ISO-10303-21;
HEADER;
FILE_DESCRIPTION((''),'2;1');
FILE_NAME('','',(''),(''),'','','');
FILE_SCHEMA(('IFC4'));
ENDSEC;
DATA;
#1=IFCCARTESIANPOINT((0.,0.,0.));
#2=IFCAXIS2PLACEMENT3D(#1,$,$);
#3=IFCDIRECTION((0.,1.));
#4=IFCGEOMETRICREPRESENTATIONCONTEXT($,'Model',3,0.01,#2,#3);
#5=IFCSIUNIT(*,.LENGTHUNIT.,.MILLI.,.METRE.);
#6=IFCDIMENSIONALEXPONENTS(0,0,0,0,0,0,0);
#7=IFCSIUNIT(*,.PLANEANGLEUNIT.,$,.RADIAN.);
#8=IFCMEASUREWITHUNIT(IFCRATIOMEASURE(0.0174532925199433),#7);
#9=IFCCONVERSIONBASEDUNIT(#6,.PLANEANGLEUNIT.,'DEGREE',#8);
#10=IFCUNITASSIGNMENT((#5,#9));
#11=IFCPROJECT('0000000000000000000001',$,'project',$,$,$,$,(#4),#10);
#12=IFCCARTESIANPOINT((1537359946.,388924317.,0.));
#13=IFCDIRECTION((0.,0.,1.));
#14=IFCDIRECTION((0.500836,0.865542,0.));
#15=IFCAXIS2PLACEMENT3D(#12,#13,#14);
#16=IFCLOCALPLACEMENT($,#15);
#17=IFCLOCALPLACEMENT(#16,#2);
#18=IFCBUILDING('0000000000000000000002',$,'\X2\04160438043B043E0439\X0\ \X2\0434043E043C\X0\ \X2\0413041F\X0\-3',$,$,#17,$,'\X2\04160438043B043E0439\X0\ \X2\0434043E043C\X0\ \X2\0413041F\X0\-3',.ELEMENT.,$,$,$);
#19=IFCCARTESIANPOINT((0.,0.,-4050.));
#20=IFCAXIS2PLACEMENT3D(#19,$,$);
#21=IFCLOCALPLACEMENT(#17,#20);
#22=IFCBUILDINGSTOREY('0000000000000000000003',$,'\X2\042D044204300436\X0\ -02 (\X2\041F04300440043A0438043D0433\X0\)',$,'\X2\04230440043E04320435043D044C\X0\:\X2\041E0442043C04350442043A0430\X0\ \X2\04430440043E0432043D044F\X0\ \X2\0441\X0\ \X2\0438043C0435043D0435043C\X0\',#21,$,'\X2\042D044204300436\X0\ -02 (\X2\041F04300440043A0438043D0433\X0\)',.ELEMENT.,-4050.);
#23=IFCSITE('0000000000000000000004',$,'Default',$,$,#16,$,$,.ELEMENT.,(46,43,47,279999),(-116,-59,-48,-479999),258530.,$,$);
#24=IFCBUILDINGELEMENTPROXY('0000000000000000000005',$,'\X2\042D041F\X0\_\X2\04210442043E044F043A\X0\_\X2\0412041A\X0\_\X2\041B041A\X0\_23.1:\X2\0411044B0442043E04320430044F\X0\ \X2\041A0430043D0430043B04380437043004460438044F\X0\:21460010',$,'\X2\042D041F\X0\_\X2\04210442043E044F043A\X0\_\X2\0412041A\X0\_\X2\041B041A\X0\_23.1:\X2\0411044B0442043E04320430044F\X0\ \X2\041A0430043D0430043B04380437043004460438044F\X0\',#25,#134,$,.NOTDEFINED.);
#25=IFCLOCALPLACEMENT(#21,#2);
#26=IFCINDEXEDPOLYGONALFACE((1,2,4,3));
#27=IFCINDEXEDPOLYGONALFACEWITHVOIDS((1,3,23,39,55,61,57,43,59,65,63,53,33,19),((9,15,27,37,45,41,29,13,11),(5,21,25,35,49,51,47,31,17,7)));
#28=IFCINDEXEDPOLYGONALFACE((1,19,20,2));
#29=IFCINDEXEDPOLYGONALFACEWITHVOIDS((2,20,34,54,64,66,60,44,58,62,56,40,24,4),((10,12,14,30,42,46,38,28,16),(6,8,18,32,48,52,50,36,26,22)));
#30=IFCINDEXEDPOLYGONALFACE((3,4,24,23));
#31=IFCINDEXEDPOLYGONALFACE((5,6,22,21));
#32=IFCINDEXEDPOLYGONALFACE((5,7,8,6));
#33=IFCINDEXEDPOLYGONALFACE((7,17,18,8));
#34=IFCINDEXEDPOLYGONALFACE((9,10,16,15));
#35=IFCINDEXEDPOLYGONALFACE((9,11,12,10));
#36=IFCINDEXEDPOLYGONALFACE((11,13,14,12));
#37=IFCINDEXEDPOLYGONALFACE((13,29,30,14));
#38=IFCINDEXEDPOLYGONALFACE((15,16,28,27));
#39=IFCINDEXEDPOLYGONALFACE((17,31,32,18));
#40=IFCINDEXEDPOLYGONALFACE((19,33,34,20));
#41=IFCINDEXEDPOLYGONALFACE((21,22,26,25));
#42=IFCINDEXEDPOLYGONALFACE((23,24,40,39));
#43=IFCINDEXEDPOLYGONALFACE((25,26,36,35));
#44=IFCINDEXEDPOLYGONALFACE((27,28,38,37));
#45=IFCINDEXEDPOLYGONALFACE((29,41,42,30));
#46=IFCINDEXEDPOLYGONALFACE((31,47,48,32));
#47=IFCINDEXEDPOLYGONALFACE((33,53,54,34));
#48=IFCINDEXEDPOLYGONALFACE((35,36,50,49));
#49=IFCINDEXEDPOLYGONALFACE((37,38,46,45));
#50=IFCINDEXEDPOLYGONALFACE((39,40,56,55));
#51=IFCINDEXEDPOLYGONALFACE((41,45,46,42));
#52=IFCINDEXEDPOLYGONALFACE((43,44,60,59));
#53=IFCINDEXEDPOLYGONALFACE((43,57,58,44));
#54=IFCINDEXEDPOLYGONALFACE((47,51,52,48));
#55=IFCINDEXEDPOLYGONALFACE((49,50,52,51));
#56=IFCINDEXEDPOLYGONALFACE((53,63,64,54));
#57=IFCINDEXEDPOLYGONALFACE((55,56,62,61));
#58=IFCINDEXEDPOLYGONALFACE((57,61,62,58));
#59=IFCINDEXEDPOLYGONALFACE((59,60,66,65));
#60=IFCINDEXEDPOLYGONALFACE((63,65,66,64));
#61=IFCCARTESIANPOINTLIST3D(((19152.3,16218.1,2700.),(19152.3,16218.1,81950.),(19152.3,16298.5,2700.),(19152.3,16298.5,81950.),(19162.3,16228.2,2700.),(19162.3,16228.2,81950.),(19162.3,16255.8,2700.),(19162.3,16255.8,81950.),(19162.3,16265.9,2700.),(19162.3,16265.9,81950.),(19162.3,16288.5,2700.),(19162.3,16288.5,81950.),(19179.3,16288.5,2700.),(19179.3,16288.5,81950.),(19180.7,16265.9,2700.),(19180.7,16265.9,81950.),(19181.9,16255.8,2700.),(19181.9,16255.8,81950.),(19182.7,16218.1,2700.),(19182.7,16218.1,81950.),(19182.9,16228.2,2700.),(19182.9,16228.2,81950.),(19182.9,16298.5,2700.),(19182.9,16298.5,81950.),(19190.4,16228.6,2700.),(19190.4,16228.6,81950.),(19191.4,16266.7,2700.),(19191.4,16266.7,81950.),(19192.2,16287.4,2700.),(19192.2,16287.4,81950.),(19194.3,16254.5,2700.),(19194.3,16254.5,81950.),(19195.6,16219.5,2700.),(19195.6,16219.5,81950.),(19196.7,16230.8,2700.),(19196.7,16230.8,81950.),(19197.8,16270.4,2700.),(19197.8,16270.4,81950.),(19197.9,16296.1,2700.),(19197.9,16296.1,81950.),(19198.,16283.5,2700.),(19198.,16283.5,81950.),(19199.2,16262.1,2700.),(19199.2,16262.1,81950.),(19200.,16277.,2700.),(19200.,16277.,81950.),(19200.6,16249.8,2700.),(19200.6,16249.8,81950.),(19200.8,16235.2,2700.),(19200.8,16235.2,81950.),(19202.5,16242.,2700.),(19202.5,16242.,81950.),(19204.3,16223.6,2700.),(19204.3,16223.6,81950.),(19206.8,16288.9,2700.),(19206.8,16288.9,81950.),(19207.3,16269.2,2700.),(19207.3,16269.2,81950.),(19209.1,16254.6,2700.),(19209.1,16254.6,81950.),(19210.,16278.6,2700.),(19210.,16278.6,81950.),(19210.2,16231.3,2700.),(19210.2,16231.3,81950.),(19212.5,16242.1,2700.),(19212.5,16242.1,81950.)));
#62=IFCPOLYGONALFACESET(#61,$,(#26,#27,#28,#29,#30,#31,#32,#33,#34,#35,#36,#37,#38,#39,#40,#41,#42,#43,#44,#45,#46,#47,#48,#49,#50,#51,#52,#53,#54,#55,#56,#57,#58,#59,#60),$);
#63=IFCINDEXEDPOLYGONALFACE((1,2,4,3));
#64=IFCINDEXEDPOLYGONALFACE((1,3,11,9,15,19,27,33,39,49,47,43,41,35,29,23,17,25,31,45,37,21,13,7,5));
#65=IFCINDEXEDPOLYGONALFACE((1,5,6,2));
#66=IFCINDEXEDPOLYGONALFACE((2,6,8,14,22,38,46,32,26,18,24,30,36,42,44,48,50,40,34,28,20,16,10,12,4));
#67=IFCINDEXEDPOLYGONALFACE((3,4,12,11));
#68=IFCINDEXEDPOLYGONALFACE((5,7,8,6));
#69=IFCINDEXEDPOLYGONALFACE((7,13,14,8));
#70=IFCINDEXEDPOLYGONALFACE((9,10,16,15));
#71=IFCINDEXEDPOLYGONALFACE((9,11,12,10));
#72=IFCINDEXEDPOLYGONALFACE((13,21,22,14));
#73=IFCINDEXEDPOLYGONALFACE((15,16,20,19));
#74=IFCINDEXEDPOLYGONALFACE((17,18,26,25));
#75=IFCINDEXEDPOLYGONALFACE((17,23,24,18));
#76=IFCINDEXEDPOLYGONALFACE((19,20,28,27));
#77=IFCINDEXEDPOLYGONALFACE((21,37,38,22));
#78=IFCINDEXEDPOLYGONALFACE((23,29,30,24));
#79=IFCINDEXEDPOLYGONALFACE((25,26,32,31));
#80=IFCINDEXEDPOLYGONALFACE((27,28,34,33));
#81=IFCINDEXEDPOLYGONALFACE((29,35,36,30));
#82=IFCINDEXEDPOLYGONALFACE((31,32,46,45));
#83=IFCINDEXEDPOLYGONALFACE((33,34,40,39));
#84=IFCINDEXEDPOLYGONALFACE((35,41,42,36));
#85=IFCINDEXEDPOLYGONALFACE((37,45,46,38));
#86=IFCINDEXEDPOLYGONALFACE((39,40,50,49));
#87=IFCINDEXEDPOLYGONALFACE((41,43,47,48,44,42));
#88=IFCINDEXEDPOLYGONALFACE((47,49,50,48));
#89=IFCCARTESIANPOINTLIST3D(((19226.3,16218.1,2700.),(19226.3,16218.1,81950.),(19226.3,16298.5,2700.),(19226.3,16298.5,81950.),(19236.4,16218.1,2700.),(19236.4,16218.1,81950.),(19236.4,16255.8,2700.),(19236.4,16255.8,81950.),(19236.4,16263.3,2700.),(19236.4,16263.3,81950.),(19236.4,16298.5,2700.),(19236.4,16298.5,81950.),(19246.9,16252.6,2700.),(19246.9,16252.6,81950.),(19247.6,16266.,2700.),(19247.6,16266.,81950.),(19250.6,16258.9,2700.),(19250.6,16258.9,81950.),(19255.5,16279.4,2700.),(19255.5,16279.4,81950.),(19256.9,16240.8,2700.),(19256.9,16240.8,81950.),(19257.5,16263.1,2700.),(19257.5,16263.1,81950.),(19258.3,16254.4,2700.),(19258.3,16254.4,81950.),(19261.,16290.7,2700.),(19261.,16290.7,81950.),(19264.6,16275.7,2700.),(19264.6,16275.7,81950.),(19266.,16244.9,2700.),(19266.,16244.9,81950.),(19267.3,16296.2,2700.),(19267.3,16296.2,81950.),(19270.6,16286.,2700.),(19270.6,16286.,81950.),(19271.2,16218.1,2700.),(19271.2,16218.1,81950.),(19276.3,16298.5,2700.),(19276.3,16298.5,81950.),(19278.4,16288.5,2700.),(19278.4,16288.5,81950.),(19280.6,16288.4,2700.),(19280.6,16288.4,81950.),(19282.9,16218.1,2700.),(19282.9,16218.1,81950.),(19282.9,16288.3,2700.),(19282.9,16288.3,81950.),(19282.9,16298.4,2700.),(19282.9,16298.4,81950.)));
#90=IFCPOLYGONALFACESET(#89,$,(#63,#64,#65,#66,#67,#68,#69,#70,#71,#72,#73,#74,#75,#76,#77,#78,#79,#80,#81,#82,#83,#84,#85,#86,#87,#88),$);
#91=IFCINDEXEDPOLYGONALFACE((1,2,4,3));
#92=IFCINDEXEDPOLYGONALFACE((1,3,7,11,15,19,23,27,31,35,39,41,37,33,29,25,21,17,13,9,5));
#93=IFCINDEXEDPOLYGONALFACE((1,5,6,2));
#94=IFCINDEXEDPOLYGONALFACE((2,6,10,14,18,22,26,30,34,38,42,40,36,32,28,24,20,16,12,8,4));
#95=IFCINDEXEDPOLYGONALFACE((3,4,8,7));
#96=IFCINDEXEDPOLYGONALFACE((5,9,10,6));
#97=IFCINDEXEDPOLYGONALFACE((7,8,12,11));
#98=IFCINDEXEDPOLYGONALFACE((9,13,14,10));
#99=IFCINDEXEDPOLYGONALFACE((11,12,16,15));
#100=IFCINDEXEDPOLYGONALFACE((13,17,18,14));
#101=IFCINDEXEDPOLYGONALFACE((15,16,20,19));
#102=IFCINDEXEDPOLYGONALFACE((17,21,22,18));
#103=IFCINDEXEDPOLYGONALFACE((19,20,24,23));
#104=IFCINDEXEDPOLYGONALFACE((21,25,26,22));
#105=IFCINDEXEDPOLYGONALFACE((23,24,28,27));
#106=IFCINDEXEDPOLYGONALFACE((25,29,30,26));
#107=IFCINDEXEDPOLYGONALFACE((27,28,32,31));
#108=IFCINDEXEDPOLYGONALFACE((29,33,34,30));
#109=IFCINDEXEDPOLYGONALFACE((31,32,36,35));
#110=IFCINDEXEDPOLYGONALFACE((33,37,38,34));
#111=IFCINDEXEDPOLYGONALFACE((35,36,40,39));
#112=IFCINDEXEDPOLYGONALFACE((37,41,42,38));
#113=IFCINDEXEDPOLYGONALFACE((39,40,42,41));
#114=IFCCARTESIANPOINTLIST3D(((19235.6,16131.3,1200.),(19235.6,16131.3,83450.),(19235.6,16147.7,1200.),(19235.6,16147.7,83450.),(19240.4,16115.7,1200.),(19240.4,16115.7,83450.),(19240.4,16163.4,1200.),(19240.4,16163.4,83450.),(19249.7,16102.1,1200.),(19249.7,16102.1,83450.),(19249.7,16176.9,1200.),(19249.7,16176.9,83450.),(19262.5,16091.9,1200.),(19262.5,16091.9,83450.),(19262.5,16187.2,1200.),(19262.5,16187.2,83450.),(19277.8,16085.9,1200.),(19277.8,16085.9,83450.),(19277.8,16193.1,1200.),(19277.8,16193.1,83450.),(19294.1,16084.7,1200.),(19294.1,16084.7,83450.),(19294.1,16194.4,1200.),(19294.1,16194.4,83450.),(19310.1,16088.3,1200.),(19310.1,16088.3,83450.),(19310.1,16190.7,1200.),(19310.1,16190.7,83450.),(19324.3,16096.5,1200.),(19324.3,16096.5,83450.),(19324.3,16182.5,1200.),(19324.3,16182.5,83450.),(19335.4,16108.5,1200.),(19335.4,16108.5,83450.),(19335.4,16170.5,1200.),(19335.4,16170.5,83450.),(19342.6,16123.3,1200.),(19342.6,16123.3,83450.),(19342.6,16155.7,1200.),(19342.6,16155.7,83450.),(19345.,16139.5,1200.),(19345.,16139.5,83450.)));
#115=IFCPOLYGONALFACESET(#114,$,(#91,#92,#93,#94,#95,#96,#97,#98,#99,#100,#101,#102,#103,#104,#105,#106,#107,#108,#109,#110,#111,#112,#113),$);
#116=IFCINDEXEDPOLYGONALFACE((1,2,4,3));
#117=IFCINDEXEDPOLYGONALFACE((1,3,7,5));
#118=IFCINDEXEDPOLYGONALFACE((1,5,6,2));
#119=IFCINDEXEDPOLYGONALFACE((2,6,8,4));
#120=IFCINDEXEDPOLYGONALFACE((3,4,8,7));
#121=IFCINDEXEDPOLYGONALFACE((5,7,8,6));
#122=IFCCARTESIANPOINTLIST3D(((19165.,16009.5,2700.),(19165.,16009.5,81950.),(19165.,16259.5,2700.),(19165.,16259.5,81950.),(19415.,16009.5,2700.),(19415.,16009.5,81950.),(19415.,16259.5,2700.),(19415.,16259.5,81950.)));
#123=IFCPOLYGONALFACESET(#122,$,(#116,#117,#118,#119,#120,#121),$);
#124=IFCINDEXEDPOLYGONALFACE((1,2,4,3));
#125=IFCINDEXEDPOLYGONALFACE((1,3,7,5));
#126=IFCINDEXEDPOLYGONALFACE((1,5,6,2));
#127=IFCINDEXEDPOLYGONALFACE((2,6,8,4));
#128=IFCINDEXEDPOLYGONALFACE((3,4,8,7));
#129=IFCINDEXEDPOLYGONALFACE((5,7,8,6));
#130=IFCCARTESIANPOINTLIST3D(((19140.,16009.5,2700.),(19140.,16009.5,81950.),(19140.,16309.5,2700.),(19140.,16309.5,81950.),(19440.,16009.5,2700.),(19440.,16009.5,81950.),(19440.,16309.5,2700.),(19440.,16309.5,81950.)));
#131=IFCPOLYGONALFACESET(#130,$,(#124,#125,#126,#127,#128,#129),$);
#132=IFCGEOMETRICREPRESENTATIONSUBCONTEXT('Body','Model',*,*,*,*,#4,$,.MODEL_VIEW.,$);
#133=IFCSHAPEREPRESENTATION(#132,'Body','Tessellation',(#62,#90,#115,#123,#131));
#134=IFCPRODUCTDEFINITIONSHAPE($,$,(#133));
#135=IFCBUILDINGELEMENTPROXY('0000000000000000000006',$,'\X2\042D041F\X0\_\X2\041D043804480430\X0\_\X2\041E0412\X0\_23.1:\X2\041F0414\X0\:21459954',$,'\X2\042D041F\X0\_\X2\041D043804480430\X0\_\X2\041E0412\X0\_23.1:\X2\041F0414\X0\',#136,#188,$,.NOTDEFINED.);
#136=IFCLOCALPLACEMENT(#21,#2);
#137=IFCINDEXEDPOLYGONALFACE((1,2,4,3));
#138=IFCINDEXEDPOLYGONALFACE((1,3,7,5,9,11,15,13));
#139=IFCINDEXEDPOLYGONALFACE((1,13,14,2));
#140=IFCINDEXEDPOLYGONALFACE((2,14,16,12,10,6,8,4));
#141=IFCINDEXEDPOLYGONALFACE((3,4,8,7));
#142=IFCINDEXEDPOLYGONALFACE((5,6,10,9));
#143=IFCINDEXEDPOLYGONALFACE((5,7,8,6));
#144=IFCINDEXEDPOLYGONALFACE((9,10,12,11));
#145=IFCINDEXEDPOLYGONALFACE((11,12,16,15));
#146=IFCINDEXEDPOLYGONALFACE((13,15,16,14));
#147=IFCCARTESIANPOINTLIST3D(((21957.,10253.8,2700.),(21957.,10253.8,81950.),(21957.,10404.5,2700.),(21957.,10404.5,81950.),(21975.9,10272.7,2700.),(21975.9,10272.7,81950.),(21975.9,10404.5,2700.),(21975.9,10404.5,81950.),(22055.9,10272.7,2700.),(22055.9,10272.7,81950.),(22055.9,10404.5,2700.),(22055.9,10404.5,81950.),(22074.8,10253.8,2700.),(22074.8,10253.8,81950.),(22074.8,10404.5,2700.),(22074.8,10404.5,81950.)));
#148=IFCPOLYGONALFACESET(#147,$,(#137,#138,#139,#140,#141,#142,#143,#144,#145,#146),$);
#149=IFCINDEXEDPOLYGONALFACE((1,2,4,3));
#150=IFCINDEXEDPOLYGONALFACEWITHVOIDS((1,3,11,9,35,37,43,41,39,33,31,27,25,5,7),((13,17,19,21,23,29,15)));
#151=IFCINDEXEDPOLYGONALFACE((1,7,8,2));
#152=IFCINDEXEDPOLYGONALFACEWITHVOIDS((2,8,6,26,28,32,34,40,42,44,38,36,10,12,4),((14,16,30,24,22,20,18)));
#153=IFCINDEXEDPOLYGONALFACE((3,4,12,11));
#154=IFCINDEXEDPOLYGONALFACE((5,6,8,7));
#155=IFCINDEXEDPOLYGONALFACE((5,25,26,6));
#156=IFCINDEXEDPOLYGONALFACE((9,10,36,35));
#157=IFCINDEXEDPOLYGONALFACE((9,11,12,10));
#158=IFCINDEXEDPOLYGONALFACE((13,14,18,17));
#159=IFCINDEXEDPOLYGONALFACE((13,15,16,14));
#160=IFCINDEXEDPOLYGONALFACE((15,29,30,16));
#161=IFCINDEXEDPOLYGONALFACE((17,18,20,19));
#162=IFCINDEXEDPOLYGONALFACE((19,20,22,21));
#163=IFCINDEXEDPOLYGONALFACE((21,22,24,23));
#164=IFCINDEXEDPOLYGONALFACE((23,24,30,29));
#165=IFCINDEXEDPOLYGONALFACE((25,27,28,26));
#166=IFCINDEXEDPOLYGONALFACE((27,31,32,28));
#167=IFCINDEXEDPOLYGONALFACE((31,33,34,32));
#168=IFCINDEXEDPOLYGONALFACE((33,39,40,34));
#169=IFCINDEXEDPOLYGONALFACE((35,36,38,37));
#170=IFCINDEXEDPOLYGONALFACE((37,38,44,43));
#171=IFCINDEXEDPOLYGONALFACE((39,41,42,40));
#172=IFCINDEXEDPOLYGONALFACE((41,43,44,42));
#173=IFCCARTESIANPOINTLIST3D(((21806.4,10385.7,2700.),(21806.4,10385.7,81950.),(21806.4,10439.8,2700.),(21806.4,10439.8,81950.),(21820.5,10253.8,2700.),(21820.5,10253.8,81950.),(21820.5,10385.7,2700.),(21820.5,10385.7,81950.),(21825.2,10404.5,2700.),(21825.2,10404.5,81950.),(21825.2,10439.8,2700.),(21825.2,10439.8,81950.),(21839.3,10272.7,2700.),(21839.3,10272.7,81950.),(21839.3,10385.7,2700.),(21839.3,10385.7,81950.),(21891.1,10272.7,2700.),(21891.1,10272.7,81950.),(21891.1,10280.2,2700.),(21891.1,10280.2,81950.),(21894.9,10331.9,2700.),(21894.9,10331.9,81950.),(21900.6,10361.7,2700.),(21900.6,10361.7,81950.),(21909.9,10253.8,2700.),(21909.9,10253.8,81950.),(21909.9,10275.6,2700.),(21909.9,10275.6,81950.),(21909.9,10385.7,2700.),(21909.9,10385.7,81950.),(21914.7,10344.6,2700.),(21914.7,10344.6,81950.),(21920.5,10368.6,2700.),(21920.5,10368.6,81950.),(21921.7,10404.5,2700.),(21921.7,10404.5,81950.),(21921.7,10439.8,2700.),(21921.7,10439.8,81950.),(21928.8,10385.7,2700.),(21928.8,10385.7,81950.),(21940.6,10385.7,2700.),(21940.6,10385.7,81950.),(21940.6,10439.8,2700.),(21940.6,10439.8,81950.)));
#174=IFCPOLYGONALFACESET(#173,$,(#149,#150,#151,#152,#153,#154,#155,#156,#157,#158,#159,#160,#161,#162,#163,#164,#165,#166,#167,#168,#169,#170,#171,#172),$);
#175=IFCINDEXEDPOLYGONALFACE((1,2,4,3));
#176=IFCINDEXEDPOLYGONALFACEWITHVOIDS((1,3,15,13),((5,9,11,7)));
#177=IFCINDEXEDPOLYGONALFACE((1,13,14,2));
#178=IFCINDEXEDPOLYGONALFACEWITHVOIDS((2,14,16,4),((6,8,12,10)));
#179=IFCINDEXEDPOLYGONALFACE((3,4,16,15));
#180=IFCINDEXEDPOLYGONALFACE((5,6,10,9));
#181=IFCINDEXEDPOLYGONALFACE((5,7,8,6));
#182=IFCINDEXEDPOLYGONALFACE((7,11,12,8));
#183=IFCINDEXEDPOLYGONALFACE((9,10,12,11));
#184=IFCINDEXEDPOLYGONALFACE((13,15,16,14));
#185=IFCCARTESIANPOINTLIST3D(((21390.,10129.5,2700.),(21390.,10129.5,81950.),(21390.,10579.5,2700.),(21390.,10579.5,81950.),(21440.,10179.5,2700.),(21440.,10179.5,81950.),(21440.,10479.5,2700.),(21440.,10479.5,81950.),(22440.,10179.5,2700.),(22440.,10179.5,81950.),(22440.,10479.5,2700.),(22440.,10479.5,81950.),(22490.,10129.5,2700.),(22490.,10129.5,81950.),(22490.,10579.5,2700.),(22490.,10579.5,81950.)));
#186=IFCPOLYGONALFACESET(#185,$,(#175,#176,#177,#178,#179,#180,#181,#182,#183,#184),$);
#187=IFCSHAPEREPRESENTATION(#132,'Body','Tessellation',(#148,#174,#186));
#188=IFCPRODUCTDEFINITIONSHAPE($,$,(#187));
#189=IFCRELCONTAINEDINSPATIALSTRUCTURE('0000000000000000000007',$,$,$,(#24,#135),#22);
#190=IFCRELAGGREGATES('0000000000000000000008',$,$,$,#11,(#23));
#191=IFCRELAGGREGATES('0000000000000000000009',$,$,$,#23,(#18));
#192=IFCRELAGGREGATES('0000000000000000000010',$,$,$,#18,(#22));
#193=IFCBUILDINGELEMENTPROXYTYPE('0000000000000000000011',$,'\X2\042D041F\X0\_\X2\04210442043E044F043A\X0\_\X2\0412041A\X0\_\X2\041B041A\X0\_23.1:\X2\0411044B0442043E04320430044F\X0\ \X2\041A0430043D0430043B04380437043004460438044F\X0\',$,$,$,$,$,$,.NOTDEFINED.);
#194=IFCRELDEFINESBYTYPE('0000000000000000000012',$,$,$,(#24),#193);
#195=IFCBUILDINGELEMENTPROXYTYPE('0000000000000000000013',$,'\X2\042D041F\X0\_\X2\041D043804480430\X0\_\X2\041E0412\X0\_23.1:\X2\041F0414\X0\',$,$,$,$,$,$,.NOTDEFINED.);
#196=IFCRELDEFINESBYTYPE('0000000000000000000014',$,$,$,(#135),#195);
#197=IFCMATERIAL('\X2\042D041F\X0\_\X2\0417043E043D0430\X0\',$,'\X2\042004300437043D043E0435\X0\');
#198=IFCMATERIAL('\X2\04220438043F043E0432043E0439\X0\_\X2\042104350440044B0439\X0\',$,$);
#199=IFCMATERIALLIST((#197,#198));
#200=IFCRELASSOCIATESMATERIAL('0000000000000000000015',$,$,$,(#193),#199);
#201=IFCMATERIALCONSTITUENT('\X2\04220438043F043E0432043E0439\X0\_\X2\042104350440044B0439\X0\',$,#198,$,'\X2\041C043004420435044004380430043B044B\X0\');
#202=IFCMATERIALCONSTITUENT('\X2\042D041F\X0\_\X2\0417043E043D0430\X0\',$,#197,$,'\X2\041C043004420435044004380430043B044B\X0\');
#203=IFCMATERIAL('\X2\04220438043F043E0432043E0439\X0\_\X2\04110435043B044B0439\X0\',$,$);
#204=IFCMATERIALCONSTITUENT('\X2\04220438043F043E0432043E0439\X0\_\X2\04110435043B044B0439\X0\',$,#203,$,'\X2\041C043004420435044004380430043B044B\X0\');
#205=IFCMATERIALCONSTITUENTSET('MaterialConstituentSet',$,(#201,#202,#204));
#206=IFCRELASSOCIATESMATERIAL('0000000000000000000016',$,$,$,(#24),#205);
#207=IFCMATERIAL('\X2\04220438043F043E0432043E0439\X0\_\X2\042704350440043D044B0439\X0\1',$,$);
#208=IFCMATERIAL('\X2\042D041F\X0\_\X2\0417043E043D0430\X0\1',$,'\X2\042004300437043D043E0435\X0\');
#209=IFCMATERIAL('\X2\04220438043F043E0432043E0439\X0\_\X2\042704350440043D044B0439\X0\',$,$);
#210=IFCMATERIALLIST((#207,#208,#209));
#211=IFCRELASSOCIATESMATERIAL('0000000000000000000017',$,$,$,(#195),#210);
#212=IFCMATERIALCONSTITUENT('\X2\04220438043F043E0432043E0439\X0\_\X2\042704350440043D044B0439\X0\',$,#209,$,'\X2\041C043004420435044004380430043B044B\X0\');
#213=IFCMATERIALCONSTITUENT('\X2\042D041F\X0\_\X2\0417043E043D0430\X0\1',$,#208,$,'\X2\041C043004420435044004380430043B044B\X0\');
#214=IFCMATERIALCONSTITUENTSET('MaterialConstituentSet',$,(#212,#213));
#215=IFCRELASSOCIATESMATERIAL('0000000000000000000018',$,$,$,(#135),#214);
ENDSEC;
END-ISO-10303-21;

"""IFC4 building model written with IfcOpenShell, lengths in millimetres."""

from ifc_helpers import new_model, entity, si_unit, converted_unit, direction, frame, frame_2d, origin, place, context, subcontext, project, spatial, polyline, rectangle, circle, outline, extrude, source, transform, mapped, material, material_list, constituent, constituent_set, type_object, type_shapes, element, save


model = new_model("IFC4")

# Units and contexts
model_context = context("Model", 3, precision=0.01, world=origin(), true_north=direction((0.0, 1.0)))
body_context = subcontext(model_context, "Body", "Model", "MODEL_VIEW")
ifc_project = project(units=[si_unit("LENGTHUNIT", "METRE", prefix="MILLI"), converted_unit("PLANEANGLEUNIT", "DEGREE", entity("IfcRatioMeasure", 0.0174532925199433), si_unit("PLANEANGLEUNIT", "RADIAN"), dimensions=[0, 0, 0, 0, 0, 0, 0])], contexts=[model_context])

# Site, building, storey
site_placement = place(None, frame((1537359946.0, 388924317.0, 0.0), z_axis=(0.0, 0.0, 1.0), x_axis=(0.500836, 0.865542, 0.0)))
site = spatial("IfcSite", under=ifc_project, at=site_placement, Name="Default", CompositionType="ELEMENT", RefLatitude=(46, 43, 47, 279999), RefLongitude=(-116, -59, -48, -479999), RefElevation=258530.0)
building_placement = place(site_placement, origin())
building = spatial("IfcBuilding", under=site, at=building_placement, Name="Жилой дом ГП-3", LongName="Жилой дом ГП-3", CompositionType="ELEMENT")
storey_placement = place(building_placement, frame((0.0, 0.0, -4050.0)))
storey = spatial("IfcBuildingStorey", under=building, at=storey_placement, Name="Этаж -02 (Паркинг)", ObjectType="Уровень:Отметка уровня с именем", LongName="Этаж -02 (Паркинг)", CompositionType="ELEMENT", Elevation=-4050.0)

# Building element proxies
ifc_material_1 = material(Name="Типовой_Черный")
ifc_material_2 = material(Name="ЭП_Зона", Category="Разное")
ifc_material_3 = material(Name="Типовой_Белый")
ifc_material_4 = material(Name="ЭП_Зона1", Category="Разное")
ifc_material_5 = material(Name="Типовой_Черный1")
ifc_material_6 = material(Name="Типовой_Серый")
ifc_material_list_1 = material_list([ifc_material_2, ifc_material_6])
building_element_proxy_type_1 = type_object("IfcBuildingElementProxyType", Name="ЭП_Стояк_ВК_ЛК_23.1:Бытовая Канализация", PredefinedType="NOTDEFINED", material=ifc_material_list_1)
shared_shape_1 = source(origin(), body_context, "Body", "SweptSolid", [
    extrude(outline(polyline([(-42.2, -39.0), (-11.8, -39.0), (1.1, -37.6), (9.8, -33.5), (15.7, -25.8), (18.0, -15.0), (14.6, -2.5), (4.7, 5.0), (12.8, 12.1), (15.5, 21.5), (12.3, 31.8), (3.4, 39.0), (-11.6, 41.4), (-42.2, 41.4), (-42.2, -39.0)]), holes=[polyline([(-32.2, 8.8), (-32.2, 31.4), (-15.2, 31.4), (-2.3, 30.3), (3.5, 26.4), (5.5, 19.9), (3.3, 13.3), (-3.1, 9.6), (-13.9, 8.8), (-32.2, 8.8)]), polyline([(-32.2, -28.9), (-32.2, -1.3), (-12.6, -1.3), (-0.2, -2.6), (6.1, -7.3), (8.0, -15.1), (6.3, -21.9), (2.2, -26.3), (-4.1, -28.5), (-11.6, -28.9), (-32.2, -28.9)])]), frame((54.5, -52.4, -1350.0)), (0.0, 0.0, 1.0), 79250.0),
    extrude(outline(polyline([(-32.1, -31.9), (48.3, -31.9), (48.3, -21.8), (10.6, -21.8), (13.8, -11.4), (25.6, -1.3), (48.3, 13.0), (48.3, 24.6), (21.4, 7.7), (12.0, 0.1), (7.4, -7.7), (3.3, -0.7), (-9.3, 6.4), (-19.7, 12.3), (-22.1, 20.2), (-22.0, 22.4), (-22.0, 24.6), (-32.0, 24.6), (-32.1, 18.0), (-29.9, 9.0), (-24.3, 2.8), (-13.1, -2.8), (0.4, -10.6), (3.0, -21.8), (-32.1, -21.8), (-32.1, -31.9)])), frame((118.2, -43.1, -1350.0), z_axis=(0.0, 0.0, 1.0), x_axis=(0.0, -1.0, 0.0)), (0.0, 0.0, 1.0), 79250.0),
    extrude(circle(Radius=55.0, at=frame_2d((0.0, 0.0), x_axis=(1.0, 0.0))), frame((150.0, -170.0, -2850.0)), (0.0, 0.0, 1.0), 82250.0),
    extrude(rectangle(XDim=250.0, YDim=250.0, at=frame_2d((0.0, 0.0), x_axis=(1.0, 0.0))), frame((150.0, -175.0, -1350.0)), (0.0, 0.0, 1.0), 79250.0),
    extrude(rectangle(XDim=300.0, YDim=300.0, at=frame_2d((0.0, 0.0), x_axis=(1.0, 0.0))), frame((150.0, -150.0, -1350.0)), (0.0, 0.0, 1.0), 79250.0),
])
type_shapes(building_element_proxy_type_1, [shared_shape_1])
ifc_constituent_1 = constituent(ifc_material_6, Name="Типовой_Серый", Category="Материалы")
ifc_constituent_2 = constituent(ifc_material_2, Name="ЭП_Зона", Category="Материалы")
ifc_constituent_3 = constituent(ifc_material_3, Name="Типовой_Белый", Category="Материалы")
ifc_constituent_set_1 = constituent_set(constituents=[ifc_constituent_1, ifc_constituent_2, ifc_constituent_3], Name="MaterialConstituentSet")
proxy_1_placement = place(storey_placement, frame((19140.0, 16309.5, 4050.0)))
element("IfcBuildingElementProxy", 1, at=proxy_1_placement, inside=storey, type_object=building_element_proxy_type_1, material=ifc_constituent_set_1, Name="ЭП_Стояк_ВК_ЛК_23.1:Бытовая Канализация:21460010", ObjectType="ЭП_Стояк_ВК_ЛК_23.1:Бытовая Канализация", PredefinedType="NOTDEFINED", context=body_context, shape_type="MappedRepresentation", body=[
    mapped(shared_shape_1, transform((0.0, 0.0, 0.0), scale=1.0)),
])
ifc_constituent_4 = constituent(ifc_material_1, Name="Типовой_Черный", Category="Материалы")
ifc_constituent_5 = constituent(ifc_material_4, Name="ЭП_Зона1", Category="Материалы")
ifc_constituent_set_2 = constituent_set(constituents=[ifc_constituent_4, ifc_constituent_5], Name="MaterialConstituentSet")
ifc_material_list_2 = material_list([ifc_material_5, ifc_material_4, ifc_material_1])
building_element_proxy_type_2 = type_object("IfcBuildingElementProxyType", Name="ЭП_Ниша_ОВ_23.1:ПД", PredefinedType="NOTDEFINED", material=ifc_material_list_2)
shared_shape_2 = source(origin(), body_context, "Body", "SweptSolid", [
    extrude(outline(polyline([(-80.1, -58.9), (70.6, -58.9), (70.6, -40.0), (-61.2, -40.0), (-61.2, 40.0), (70.6, 40.0), (70.6, 58.9), (-80.1, 58.9), (-80.1, -58.9)])), frame((474.1, 245.6, 0.0), z_axis=(0.0, 0.0, 1.0), x_axis=(0.0, -1.0, 0.0)), (0.0, 0.0, 1.0), 79250.0),
    extrude(outline(polyline([(-120.0, 29.1), (-120.0, -60.4), (11.8, -60.4), (11.8, -74.5), (66.0, -74.5), (66.0, -55.6), (30.7, -55.6), (30.7, 40.9), (66.0, 40.9), (66.0, 59.7), (11.8, 59.7), (11.8, 48.0), (-5.2, 39.7), (-29.3, 33.8), (-98.2, 29.1), (-120.0, 29.1)]), holes=[polyline([(-101.2, -41.5), (-101.2, 10.3), (-93.6, 10.3), (-42.0, 14.1), (-12.2, 19.8), (11.8, 29.1), (11.8, -41.5), (-101.2, -41.5)])]), frame((609.2, 205.7, 0.0), z_axis=(0.0, 0.0, -1.0), x_axis=(0.0, -1.0, 0.0)), (0.0, 0.0, -1.0), 79250.0),
    extrude(outline(polyline([(-550.0, -225.0), (550.0, -225.0), (550.0, 225.0), (-550.0, 225.0), (-550.0, -225.0)]), holes=[polyline([(500.0, 175.0), (500.0, -125.0), (-500.0, -125.0), (-500.0, 175.0), (500.0, 175.0)])]), frame((550.0, 225.0, 0.0)), (0.0, 0.0, 1.0), 79250.0),
])
type_shapes(building_element_proxy_type_2, [shared_shape_2])
proxy_2_placement = place(storey_placement, frame((22490.0, 10579.5, 2700.0), z_axis=(0.0, 0.0, 1.0), x_axis=(-1.0, 0.0, 0.0)))
element("IfcBuildingElementProxy", 2, at=proxy_2_placement, inside=storey, type_object=building_element_proxy_type_2, material=ifc_constituent_set_2, Name="ЭП_Ниша_ОВ_23.1:ПД:21459954", ObjectType="ЭП_Ниша_ОВ_23.1:ПД", PredefinedType="NOTDEFINED", context=body_context, shape_type="MappedRepresentation", body=[
    mapped(shared_shape_2, transform((0.0, 0.0, 0.0), scale=1.0)),
])

save(model, "model.ifc")
